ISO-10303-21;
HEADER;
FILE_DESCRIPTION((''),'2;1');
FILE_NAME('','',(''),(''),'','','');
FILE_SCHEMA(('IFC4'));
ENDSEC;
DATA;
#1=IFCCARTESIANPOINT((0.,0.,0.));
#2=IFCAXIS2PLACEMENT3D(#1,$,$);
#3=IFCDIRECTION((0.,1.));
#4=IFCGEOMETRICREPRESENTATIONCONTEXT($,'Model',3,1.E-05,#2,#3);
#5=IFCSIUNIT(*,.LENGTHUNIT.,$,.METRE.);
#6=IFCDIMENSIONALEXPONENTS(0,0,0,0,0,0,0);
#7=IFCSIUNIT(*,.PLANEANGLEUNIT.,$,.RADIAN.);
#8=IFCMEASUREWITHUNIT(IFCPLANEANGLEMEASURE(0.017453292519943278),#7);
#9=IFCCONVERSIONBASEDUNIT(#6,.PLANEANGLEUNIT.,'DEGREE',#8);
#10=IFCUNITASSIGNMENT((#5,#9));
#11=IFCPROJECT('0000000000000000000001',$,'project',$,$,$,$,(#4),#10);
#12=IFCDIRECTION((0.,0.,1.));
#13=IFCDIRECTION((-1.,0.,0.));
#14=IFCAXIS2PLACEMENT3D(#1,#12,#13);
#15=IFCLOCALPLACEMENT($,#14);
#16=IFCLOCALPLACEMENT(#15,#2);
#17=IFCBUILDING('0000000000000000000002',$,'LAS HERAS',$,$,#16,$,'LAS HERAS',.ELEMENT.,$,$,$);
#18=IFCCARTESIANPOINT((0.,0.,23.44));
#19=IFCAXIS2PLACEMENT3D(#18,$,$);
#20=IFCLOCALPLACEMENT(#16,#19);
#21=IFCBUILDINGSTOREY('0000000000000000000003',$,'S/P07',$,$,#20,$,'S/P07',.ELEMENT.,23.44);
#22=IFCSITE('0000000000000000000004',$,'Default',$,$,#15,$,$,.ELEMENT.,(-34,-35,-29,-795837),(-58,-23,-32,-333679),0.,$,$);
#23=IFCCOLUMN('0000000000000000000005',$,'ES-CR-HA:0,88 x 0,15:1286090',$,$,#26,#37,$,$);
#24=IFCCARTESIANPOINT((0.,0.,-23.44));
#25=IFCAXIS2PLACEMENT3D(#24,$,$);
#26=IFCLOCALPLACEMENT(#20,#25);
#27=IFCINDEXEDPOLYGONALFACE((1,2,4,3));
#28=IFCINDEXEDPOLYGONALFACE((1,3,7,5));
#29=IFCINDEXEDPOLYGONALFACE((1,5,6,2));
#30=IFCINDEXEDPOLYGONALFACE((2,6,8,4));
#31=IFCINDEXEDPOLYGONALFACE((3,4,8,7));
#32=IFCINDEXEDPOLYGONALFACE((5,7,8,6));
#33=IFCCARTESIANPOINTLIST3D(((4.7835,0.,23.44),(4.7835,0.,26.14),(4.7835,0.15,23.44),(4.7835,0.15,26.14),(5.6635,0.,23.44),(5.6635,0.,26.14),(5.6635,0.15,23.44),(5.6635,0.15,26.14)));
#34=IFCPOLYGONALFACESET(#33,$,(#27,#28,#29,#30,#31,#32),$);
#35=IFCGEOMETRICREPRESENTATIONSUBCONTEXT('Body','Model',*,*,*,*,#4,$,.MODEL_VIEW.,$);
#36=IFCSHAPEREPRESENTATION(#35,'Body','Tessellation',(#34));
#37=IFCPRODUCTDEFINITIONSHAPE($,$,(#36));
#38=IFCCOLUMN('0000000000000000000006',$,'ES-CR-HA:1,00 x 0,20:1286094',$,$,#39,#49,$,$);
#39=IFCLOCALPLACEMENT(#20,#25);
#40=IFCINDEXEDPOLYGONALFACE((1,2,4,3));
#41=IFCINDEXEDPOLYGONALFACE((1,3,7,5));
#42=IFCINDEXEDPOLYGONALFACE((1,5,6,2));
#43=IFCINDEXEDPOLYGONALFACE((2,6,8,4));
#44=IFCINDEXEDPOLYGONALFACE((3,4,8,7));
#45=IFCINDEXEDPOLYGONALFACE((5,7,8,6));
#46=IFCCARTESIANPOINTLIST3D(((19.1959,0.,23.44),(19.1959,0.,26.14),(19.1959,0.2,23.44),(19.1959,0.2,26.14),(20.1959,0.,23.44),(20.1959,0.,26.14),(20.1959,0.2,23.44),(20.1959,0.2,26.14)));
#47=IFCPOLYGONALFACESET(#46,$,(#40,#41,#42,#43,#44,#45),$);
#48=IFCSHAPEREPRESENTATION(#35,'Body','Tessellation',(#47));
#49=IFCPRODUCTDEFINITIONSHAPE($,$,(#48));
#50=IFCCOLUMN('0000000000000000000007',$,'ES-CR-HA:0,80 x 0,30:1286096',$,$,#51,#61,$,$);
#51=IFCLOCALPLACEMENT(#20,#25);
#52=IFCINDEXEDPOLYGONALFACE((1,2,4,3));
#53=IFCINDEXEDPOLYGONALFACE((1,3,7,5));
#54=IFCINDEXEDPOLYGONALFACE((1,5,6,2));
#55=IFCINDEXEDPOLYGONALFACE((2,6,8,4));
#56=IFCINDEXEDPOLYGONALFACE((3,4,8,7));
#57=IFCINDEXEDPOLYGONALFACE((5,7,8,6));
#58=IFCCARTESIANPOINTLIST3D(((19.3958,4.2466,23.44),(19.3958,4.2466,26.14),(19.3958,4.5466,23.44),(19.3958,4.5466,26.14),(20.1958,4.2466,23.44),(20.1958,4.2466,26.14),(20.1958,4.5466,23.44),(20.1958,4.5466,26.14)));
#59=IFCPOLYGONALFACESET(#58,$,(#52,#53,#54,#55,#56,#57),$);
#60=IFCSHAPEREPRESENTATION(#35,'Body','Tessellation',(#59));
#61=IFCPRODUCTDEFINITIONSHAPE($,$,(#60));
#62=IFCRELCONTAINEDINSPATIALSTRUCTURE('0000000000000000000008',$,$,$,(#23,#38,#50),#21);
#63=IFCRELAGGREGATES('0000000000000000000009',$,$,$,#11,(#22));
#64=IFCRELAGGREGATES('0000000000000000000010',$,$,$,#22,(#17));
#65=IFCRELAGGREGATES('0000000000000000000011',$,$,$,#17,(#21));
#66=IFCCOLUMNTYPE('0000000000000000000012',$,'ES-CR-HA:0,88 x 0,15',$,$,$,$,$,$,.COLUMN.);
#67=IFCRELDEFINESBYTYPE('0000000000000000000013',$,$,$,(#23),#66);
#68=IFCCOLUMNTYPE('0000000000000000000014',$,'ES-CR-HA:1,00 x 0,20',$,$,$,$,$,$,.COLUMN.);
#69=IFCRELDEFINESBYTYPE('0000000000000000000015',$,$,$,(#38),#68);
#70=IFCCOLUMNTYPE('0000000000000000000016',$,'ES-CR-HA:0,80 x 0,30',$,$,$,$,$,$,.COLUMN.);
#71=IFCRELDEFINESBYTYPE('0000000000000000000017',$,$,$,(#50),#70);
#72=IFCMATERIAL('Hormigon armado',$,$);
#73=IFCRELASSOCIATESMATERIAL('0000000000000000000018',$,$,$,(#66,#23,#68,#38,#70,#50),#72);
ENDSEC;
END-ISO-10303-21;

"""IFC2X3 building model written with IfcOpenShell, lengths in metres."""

from ifc_helpers import new_model, entity, si_unit, converted_unit, direction, frame, frame_2d, origin, place, context, subcontext, project, spatial, rectangle, extrude, source, transform, mapped, material, type_object, type_shapes, element, save


model = new_model("IFC2X3")

# Units and contexts
model_context = context("Model", 3, precision=1e-05, world=origin(), true_north=direction((0.0, 1.0)))
body_context = subcontext(model_context, "Body", "Model", "MODEL_VIEW")
ifc_project = project(units=[si_unit("LENGTHUNIT", "METRE"), converted_unit("PLANEANGLEUNIT", "DEGREE", entity("IfcPlaneAngleMeasure", 0.017453292519943278), si_unit("PLANEANGLEUNIT", "RADIAN"), dimensions=[0, 0, 0, 0, 0, 0, 0])], contexts=[model_context])

# Site, building, storey
site_placement = place(None, frame((0.0, 0.0, 0.0), z_axis=(0.0, 0.0, 1.0), x_axis=(-1.0, 0.0, 0.0)))
site = spatial("IfcSite", under=ifc_project, at=site_placement, Name="Default", CompositionType="ELEMENT", RefLatitude=(-34, -35, -29, -795837), RefLongitude=(-58, -23, -32, -333679), RefElevation=0.0)
building_placement = place(site_placement, origin())
building = spatial("IfcBuilding", under=site, at=building_placement, Name="LAS HERAS", LongName="LAS HERAS", CompositionType="ELEMENT")
storey_placement = place(building_placement, frame((0.0, 0.0, 23.44)))
storey = spatial("IfcBuildingStorey", under=building, at=storey_placement, Name="S/P07", LongName="S/P07", CompositionType="ELEMENT", Elevation=23.44)

# Columns
ifc_material = material(Name="Hormigon armado")
column_type_1 = type_object("IfcColumnType", Name="ES-CR-HA:0,88 x 0,15", PredefinedType="COLUMN", material=ifc_material)
shared_shape_1 = source(origin(), body_context, "Body", "SweptSolid", [
    extrude(rectangle(XDim=2.7, YDim=0.15, at=frame_2d((0.0, 0.0), x_axis=(1.0, 0.0))), frame((4.7835, 0.075, 24.79), z_axis=(1.0, 0.0, 0.0), x_axis=(0.0, 0.0, 1.0)), (0.0, 0.0, 1.0), 0.88),
])
type_shapes(column_type_1, [shared_shape_1])
column_1_placement = place(storey_placement, frame((0.0, 0.0, -23.44)))
element("IfcColumn", 1, at=column_1_placement, inside=storey, type_object=column_type_1, material=ifc_material, Name="ES-CR-HA:0,88 x 0,15:1286090", context=body_context, shape_type="MappedRepresentation", body=[
    mapped(shared_shape_1, transform((0.0, 0.0, 0.0), scale=1.0)),
])
column_type_2 = type_object("IfcColumnType", Name="ES-CR-HA:1,00 x 0,20", PredefinedType="COLUMN", material=ifc_material)
shared_shape_2 = source(origin(), body_context, "Body", "SweptSolid", [
    extrude(rectangle(XDim=2.7, YDim=0.2, at=frame_2d((0.0, 0.0), x_axis=(1.0, 0.0))), frame((19.1959, 0.1, 24.79), z_axis=(1.0, 0.0, 0.0), x_axis=(0.0, 0.0, 1.0)), (0.0, 0.0, 1.0), 1.0),
])
type_shapes(column_type_2, [shared_shape_2])
column_2_placement = place(storey_placement, frame((0.0, 0.0, -23.44)))
element("IfcColumn", 2, at=column_2_placement, inside=storey, type_object=column_type_2, material=ifc_material, Name="ES-CR-HA:1,00 x 0,20:1286094", context=body_context, shape_type="MappedRepresentation", body=[
    mapped(shared_shape_2, transform((0.0, 0.0, 0.0), scale=1.0)),
])
column_type_3 = type_object("IfcColumnType", Name="ES-CR-HA:0,80 x 0,30", PredefinedType="COLUMN", material=ifc_material)
shared_shape_3 = source(origin(), body_context, "Body", "SweptSolid", [
    extrude(rectangle(XDim=2.7, YDim=0.3, at=frame_2d((0.0, 0.0), x_axis=(1.0, 0.0))), frame((19.3958, 4.3966, 24.79), z_axis=(1.0, 0.0, 0.0), x_axis=(0.0, 0.0, 1.0)), (0.0, 0.0, 1.0), 0.8),
])
type_shapes(column_type_3, [shared_shape_3])
column_3_placement = place(storey_placement, frame((0.0, 0.0, -23.44)))
element("IfcColumn", 3, at=column_3_placement, inside=storey, type_object=column_type_3, material=ifc_material, Name="ES-CR-HA:0,80 x 0,30:1286096", context=body_context, shape_type="MappedRepresentation", body=[
    mapped(shared_shape_3, transform((0.0, 0.0, 0.0), scale=1.0)),
])

save(model, "model.ifc")
